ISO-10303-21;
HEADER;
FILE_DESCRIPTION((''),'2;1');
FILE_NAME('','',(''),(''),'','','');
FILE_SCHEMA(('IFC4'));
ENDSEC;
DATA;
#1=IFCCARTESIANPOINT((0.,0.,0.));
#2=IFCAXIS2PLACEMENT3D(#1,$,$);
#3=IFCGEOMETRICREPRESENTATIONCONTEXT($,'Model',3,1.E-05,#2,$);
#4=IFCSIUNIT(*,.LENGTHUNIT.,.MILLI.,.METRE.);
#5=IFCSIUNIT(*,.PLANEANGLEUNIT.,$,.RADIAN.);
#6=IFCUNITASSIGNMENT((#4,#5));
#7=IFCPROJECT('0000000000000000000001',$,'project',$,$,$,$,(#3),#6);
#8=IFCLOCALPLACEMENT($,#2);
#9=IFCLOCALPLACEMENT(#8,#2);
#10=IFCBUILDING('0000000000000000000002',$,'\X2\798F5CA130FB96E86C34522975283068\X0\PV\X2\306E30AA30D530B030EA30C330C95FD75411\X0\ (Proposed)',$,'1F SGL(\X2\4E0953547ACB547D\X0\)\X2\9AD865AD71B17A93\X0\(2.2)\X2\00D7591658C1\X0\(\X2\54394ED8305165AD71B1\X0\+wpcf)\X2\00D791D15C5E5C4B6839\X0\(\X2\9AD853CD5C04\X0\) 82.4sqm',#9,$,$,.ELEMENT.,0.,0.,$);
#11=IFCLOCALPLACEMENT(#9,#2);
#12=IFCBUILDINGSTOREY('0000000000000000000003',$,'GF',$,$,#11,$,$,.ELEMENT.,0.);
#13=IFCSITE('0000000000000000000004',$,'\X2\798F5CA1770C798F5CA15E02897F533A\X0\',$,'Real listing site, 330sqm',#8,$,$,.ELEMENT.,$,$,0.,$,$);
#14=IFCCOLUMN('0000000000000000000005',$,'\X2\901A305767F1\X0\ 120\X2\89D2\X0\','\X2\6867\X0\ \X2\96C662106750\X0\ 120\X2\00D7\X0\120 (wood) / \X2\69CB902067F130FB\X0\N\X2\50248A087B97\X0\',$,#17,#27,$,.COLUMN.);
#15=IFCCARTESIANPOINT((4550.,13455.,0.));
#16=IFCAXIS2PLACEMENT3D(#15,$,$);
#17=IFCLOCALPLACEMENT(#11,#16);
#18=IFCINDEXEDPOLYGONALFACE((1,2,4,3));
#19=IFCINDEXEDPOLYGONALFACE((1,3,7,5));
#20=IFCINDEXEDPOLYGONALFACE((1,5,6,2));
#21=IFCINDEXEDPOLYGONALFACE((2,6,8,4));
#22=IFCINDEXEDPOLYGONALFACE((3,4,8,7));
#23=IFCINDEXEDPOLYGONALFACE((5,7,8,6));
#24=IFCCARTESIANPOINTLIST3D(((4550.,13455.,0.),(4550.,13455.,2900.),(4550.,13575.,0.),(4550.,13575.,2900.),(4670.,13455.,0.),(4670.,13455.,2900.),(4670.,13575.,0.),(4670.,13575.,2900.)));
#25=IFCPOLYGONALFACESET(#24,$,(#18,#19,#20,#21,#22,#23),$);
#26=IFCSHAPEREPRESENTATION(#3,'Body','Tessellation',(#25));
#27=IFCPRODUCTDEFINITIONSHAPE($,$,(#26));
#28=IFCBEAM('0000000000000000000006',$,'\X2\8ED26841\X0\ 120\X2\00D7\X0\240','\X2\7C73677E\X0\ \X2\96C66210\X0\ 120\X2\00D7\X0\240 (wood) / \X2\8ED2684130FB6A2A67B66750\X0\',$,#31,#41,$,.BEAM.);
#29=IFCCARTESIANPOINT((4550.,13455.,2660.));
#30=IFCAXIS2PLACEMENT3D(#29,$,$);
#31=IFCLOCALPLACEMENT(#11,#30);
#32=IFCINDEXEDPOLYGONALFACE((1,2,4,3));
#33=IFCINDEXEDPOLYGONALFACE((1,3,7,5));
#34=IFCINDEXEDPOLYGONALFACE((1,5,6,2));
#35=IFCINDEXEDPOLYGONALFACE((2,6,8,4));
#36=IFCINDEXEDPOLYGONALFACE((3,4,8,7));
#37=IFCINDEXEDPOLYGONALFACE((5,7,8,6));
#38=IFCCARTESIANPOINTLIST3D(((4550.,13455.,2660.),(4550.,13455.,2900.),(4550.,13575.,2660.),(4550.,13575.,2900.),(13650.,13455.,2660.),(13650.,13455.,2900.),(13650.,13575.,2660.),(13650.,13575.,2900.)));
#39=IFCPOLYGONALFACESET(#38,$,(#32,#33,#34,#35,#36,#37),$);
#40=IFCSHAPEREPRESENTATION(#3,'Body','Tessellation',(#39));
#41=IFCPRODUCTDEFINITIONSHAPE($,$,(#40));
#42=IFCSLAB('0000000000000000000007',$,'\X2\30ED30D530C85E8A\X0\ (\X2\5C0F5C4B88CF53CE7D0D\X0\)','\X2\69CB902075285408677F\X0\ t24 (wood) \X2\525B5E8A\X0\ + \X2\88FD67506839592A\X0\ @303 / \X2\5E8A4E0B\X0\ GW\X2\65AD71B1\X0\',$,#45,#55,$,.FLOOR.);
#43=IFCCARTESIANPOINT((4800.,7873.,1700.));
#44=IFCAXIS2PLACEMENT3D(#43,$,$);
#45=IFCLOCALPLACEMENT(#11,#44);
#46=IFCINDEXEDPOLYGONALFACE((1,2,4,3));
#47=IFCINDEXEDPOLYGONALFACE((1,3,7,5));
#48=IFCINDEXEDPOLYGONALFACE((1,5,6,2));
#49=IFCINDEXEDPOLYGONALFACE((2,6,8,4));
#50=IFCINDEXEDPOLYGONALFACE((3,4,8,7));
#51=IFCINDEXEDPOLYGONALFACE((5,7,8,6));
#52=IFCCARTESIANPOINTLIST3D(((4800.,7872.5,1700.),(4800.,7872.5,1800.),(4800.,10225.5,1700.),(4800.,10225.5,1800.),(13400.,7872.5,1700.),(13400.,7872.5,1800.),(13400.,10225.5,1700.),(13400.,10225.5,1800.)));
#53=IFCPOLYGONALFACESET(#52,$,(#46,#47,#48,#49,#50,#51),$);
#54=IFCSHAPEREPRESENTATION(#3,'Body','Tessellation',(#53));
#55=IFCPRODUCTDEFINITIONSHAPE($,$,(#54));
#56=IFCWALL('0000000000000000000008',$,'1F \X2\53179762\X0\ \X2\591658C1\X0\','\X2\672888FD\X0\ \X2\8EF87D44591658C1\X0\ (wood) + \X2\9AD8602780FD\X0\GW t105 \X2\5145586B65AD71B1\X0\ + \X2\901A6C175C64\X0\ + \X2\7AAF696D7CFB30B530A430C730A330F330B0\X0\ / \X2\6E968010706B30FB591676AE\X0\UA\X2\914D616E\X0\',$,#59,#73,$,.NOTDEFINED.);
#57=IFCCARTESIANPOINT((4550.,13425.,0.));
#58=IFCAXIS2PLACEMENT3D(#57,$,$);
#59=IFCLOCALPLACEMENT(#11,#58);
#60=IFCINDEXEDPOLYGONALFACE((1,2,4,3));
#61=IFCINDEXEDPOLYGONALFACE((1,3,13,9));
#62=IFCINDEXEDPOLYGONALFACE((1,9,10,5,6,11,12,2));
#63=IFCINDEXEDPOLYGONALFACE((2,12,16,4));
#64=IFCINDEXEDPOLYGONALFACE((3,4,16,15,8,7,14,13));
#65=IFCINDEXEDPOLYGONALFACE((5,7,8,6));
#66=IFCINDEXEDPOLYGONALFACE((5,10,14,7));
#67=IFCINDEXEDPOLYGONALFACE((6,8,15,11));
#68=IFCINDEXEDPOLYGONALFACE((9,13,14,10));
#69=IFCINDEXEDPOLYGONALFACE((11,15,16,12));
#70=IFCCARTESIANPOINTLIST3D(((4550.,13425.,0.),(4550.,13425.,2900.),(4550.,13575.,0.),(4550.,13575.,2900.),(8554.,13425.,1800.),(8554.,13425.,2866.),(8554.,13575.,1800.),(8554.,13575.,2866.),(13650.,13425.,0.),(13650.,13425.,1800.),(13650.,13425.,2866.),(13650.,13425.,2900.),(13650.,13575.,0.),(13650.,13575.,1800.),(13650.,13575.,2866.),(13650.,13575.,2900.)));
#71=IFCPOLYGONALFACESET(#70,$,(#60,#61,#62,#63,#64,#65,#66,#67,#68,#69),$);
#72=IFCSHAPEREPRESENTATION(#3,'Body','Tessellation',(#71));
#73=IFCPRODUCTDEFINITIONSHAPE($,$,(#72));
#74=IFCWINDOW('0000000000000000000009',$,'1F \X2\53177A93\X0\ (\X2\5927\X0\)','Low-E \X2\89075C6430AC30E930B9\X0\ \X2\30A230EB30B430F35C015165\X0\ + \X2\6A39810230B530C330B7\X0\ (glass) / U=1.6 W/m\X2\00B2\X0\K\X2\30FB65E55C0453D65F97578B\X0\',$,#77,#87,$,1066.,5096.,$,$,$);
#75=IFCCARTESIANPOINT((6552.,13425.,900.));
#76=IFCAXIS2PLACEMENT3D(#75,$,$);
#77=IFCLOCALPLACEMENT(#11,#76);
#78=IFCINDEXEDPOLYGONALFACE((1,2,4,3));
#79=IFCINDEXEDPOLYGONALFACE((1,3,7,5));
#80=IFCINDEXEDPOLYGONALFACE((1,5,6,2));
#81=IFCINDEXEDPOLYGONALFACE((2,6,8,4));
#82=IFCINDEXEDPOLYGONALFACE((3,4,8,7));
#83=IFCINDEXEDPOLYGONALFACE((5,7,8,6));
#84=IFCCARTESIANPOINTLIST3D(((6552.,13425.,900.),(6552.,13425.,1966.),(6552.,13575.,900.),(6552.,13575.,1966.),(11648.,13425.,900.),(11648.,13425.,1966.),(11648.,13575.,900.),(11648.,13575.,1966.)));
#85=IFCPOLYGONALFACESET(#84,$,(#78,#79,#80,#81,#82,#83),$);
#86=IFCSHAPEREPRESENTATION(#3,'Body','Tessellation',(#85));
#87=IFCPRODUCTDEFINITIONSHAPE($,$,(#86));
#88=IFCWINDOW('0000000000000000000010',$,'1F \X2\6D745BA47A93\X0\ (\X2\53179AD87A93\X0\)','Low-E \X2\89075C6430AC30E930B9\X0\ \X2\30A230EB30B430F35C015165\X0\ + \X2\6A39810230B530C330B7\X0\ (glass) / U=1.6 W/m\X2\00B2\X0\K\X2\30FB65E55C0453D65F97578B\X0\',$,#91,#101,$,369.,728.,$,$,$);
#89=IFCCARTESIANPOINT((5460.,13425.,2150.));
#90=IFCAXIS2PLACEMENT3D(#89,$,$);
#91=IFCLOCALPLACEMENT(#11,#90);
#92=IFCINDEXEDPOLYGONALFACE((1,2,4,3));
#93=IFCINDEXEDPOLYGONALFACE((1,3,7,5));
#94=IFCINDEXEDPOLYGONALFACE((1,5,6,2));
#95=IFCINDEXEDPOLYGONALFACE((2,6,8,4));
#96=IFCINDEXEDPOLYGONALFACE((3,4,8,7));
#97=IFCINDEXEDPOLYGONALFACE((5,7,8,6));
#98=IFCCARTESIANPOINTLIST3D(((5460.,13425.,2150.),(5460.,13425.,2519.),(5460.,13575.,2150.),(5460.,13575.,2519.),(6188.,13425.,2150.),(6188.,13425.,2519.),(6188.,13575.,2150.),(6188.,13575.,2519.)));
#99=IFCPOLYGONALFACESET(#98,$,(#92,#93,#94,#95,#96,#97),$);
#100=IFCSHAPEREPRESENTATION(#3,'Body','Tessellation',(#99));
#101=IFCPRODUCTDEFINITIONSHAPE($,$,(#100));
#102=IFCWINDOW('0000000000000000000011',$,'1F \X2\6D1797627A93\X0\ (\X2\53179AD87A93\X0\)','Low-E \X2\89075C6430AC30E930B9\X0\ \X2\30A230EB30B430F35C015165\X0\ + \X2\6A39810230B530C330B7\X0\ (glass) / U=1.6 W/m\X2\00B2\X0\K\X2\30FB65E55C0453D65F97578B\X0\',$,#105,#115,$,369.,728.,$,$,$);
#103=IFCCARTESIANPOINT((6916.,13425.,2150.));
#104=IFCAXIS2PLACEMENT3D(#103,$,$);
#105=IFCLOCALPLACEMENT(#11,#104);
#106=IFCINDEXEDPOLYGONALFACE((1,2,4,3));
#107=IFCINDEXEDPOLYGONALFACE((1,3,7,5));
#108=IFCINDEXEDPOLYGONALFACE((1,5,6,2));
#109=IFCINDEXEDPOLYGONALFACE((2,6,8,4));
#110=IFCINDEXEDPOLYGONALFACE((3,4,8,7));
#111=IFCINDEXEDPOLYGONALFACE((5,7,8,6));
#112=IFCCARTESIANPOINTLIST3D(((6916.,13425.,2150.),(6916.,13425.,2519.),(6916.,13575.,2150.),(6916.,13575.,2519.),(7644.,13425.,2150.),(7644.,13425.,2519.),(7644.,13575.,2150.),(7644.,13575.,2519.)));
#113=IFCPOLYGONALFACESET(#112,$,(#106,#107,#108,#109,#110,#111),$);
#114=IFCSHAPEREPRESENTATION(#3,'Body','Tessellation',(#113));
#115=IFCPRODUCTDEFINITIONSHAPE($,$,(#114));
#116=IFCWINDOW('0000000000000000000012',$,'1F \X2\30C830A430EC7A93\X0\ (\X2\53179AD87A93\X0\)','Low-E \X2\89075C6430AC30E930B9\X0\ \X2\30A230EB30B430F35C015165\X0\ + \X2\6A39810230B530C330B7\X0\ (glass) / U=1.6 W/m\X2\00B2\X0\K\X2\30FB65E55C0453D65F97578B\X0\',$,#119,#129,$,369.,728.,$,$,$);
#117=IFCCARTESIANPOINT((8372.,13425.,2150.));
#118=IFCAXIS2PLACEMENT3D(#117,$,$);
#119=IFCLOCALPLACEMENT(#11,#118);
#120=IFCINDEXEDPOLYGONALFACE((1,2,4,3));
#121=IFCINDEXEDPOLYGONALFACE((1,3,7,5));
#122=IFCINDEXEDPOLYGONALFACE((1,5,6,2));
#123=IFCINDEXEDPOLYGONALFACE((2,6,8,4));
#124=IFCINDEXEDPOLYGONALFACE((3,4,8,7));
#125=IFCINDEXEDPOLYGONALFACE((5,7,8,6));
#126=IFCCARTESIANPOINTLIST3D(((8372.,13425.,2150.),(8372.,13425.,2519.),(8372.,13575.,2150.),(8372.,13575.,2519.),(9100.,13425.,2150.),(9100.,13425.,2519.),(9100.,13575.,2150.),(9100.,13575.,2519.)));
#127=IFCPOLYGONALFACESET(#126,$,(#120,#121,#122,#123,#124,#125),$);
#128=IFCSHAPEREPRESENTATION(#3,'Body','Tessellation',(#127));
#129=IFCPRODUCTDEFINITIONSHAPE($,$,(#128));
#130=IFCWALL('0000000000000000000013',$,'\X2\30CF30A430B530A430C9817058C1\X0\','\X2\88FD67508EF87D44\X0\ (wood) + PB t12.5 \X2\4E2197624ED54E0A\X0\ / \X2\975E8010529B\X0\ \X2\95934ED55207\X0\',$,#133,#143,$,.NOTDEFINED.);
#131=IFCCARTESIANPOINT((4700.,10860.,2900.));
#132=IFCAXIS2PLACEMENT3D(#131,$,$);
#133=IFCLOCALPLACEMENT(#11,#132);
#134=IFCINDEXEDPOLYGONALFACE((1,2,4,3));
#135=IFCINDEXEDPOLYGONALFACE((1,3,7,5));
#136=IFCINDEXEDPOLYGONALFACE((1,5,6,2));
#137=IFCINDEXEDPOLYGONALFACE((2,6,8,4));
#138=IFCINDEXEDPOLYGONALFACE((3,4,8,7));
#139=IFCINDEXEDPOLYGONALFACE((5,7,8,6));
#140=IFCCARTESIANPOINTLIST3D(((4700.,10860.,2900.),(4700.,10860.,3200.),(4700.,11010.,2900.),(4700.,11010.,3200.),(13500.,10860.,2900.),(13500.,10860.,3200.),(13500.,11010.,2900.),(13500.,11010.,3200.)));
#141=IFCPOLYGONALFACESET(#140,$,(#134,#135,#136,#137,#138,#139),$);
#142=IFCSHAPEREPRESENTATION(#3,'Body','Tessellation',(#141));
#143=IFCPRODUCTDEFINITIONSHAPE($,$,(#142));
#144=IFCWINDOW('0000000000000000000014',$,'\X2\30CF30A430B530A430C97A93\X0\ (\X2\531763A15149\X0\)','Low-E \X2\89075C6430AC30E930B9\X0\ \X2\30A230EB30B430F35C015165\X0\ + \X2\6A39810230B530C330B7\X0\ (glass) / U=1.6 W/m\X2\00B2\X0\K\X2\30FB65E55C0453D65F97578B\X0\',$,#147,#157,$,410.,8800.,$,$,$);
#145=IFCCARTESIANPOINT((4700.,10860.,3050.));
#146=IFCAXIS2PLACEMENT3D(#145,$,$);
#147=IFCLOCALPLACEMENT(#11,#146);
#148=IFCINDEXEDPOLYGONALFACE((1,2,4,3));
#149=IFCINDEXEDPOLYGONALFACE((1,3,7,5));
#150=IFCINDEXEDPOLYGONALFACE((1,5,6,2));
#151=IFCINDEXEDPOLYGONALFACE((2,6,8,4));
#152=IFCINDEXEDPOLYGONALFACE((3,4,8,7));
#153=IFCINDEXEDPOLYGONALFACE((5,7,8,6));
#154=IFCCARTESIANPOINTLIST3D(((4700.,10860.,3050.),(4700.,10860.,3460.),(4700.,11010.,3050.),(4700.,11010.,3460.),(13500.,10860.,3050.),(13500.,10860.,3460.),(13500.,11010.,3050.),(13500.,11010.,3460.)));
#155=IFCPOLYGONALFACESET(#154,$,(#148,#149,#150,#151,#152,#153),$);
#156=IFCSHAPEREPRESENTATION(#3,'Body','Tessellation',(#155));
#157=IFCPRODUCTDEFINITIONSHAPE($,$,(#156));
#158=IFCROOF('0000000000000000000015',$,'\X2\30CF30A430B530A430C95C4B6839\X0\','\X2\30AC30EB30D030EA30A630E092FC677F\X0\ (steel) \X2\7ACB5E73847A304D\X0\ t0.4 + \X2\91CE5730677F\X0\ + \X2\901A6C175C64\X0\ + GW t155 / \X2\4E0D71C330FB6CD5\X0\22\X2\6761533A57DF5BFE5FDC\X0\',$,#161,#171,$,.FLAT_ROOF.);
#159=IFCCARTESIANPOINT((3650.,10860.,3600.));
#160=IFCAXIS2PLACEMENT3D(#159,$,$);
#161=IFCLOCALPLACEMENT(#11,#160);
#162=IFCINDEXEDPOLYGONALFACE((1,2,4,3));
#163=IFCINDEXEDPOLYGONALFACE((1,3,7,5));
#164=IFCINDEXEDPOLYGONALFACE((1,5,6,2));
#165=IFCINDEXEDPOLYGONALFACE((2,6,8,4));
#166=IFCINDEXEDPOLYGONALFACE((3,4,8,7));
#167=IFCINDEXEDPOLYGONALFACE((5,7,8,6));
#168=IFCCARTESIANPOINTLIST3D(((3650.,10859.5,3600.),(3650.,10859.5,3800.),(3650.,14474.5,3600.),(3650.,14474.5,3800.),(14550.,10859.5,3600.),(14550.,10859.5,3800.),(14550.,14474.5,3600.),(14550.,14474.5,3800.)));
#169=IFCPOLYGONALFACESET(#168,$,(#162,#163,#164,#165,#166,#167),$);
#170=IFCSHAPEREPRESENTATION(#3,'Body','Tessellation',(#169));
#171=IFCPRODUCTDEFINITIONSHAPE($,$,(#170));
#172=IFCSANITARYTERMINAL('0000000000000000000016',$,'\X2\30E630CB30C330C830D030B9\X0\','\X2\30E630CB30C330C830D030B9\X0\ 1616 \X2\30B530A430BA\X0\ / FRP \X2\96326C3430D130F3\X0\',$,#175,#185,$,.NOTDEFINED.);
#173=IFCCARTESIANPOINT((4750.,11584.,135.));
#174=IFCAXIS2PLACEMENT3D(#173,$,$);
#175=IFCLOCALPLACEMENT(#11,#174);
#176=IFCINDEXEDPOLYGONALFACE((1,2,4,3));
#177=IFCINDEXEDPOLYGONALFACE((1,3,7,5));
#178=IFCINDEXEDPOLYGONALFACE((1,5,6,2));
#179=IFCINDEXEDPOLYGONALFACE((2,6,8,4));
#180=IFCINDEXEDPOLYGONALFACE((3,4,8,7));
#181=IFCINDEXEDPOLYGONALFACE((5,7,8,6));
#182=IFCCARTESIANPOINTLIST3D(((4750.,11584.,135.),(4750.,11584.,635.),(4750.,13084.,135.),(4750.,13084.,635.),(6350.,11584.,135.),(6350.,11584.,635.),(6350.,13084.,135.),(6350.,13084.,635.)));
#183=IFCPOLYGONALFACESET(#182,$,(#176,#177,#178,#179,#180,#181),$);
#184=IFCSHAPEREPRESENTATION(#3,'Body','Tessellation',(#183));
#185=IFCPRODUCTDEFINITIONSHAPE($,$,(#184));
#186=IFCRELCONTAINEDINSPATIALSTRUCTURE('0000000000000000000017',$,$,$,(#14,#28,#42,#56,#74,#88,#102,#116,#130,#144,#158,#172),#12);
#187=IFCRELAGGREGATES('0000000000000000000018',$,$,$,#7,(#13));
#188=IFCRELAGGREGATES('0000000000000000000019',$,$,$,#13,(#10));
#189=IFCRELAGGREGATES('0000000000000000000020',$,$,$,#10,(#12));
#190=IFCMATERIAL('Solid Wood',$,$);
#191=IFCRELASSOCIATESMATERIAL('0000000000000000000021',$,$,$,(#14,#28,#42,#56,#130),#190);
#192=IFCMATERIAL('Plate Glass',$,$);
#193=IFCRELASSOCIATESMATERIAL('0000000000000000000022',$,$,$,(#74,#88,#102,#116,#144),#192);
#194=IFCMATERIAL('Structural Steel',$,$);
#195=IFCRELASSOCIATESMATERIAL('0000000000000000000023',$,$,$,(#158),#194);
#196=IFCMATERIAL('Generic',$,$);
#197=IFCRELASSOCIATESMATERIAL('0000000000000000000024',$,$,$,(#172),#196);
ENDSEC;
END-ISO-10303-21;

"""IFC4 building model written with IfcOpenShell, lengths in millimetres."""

from ifc_helpers import new_model, si_unit, frame, frame_2d, origin, place, context, project, spatial, rectangle, extrude, material, element, fill, save


model = new_model("IFC4")

# Units and contexts
model_context = context("Model", 3, precision=1e-05, world=origin())
ifc_project = project(units=[si_unit("LENGTHUNIT", "METRE", prefix="MILLI"), si_unit("PLANEANGLEUNIT", "RADIAN")], contexts=[model_context])

# Site, building, storey
site_placement = place(None, origin())
site = spatial("IfcSite", under=ifc_project, at=site_placement, Name="福岡県福岡市西区", ObjectType="Real listing site, 330sqm", CompositionType="ELEMENT", RefElevation=0.0)
building_placement = place(site_placement, origin())
building = spatial("IfcBuilding", under=site, at=building_placement, Name="福岡・雨水利用とPVのオフグリッド志向 (Proposed)", ObjectType="1F SGL(三協立命)高断熱窓(2.2)×外壁(吹付け断熱+wpcf)×金属屋根(高反射) 82.4sqm", CompositionType="ELEMENT", ElevationOfRefHeight=0.0, ElevationOfTerrain=0.0)
storey_placement = place(building_placement, origin())
storey = spatial("IfcBuildingStorey", under=building, at=storey_placement, Name="GF", CompositionType="ELEMENT", Elevation=0.0)

# Column
ifc_material_1 = material(Name="Solid Wood")
column_1_placement = place(storey_placement, frame((4550.0, 13455.0, 0.0)))
element("IfcColumn", 1, at=column_1_placement, inside=storey, material=ifc_material_1, Name="通し柱 120角", Description="桧 集成材 120×120 (wood) / 構造柱・N値計算", PredefinedType="COLUMN", context=model_context, shape_type="SweptSolid", body=[
    extrude(rectangle(XDim=120.0, YDim=120.0, at=frame_2d((60.0, 60.0))), frame((4550.0, 13455.0, 0.0)), (0.0, 0.0, 1.0), 2900.0),
])

# Beam
beam_1_placement = place(storey_placement, frame((4550.0, 13455.0, 2660.0)))
element("IfcBeam", 2, at=beam_1_placement, inside=storey, material=ifc_material_1, Name="軒桁 120×240", Description="米松 集成 120×240 (wood) / 軒桁・横架材", PredefinedType="BEAM", context=model_context, shape_type="SweptSolid", body=[
    extrude(rectangle(XDim=9100.0, YDim=120.0, at=frame_2d((4550.0, 60.0))), frame((4550.0, 13455.0, 2660.0)), (0.0, 0.0, 1.0), 240.0),
])

# Slab
slab_placement = place(storey_placement, frame((4800.0, 7873.0, 1700.0)))
element("IfcSlab", 3, at=slab_placement, inside=storey, material=ifc_material_1, Name="ロフト床 (小屋裏収納)", Description="構造用合板 t24 (wood) 剛床 + 製材根太 @303 / 床下 GW断熱", PredefinedType="FLOOR", context=model_context, shape_type="SweptSolid", body=[
    extrude(rectangle(XDim=8600.0, YDim=2353.0, at=frame_2d((4300.0, 1176.0))), frame((4800.0, 7873.0, 1700.0)), (0.0, 0.0, 1.0), 100.0),
])

# Wall, openings, windows
wall_1_placement = place(storey_placement, frame((4550.0, 13425.0, 0.0)))
wall_1 = element("IfcWall", 4, at=wall_1_placement, inside=storey, material=ifc_material_1, Name="1F 北面 外壁", Description="木製 軸組外壁 (wood) + 高性能GW t105 充填断熱 + 通気層 + 窯業系サイディング / 準耐火・外皮UA配慮", PredefinedType="NOTDEFINED", context=model_context, shape_type="SweptSolid", body=[
    extrude(rectangle(XDim=9100.0, YDim=150.0, at=frame_2d((4550.0, 75.0))), frame((4550.0, 13425.0, 0.0)), (0.0, 0.0, 1.0), 2900.0),
])
opening_1_placement = place(storey_placement, frame((6552.0, 13425.0, 900.0)))
opening_1 = element("IfcOpeningElement", 5, at=opening_1_placement, cuts=wall_1, PredefinedType="NOTDEFINED", context=model_context, shape_type="SweptSolid", body=[
    extrude(rectangle(XDim=5096.0, YDim=150.0, at=frame_2d((2548.0, 75.0))), frame((6552.0, 13425.0, 900.0)), (0.0, 0.0, 1.0), 1066.0),
])
opening_2_placement = place(storey_placement, frame((5460.0, 13425.0, 2150.0)))
opening_2 = element("IfcOpeningElement", 6, at=opening_2_placement, cuts=wall_1, PredefinedType="NOTDEFINED", context=model_context, shape_type="SweptSolid", body=[
    extrude(rectangle(XDim=728.0, YDim=150.0, at=frame_2d((364.0, 75.0))), frame((5460.0, 13425.0, 2150.0)), (0.0, 0.0, 1.0), 369.0),
])
opening_3_placement = place(storey_placement, frame((6916.0, 13425.0, 2150.0)))
opening_3 = element("IfcOpeningElement", 7, at=opening_3_placement, cuts=wall_1, PredefinedType="NOTDEFINED", context=model_context, shape_type="SweptSolid", body=[
    extrude(rectangle(XDim=728.0, YDim=150.0, at=frame_2d((364.0, 75.0))), frame((6916.0, 13425.0, 2150.0)), (0.0, 0.0, 1.0), 369.0),
])
opening_4_placement = place(storey_placement, frame((8372.0, 13425.0, 2150.0)))
opening_4 = element("IfcOpeningElement", 8, at=opening_4_placement, cuts=wall_1, PredefinedType="NOTDEFINED", context=model_context, shape_type="SweptSolid", body=[
    extrude(rectangle(XDim=728.0, YDim=150.0, at=frame_2d((364.0, 75.0))), frame((8372.0, 13425.0, 2150.0)), (0.0, 0.0, 1.0), 369.0),
])
ifc_material_2 = material(Name="Plate Glass")
window_1_placement = place(storey_placement, frame((6552.0, 13425.0, 900.0)))
window_1 = element("IfcWindow", 9, at=window_1_placement, inside=storey, material=ifc_material_2, Name="1F 北窓 (大)", Description="Low-E 複層ガラス アルゴン封入 + 樹脂サッシ (glass) / U=1.6 W/m²K・日射取得型", OverallHeight=1066.0, OverallWidth=5096.0, context=model_context, shape_type="SweptSolid", body=[
    extrude(rectangle(XDim=5096.0, YDim=150.0, at=frame_2d((2548.0, 75.0))), frame((6552.0, 13425.0, 900.0)), (0.0, 0.0, 1.0), 1066.0),
])
fill(opening_1, window_1)
window_2_placement = place(storey_placement, frame((5460.0, 13425.0, 2150.0)))
window_2 = element("IfcWindow", 10, at=window_2_placement, inside=storey, material=ifc_material_2, Name="1F 浴室窓 (北高窓)", Description="Low-E 複層ガラス アルゴン封入 + 樹脂サッシ (glass) / U=1.6 W/m²K・日射取得型", OverallHeight=369.0, OverallWidth=728.0, context=model_context, shape_type="SweptSolid", body=[
    extrude(rectangle(XDim=728.0, YDim=150.0, at=frame_2d((364.0, 75.0))), frame((5460.0, 13425.0, 2150.0)), (0.0, 0.0, 1.0), 369.0),
])
fill(opening_2, window_2)
window_3_placement = place(storey_placement, frame((6916.0, 13425.0, 2150.0)))
window_3 = element("IfcWindow", 11, at=window_3_placement, inside=storey, material=ifc_material_2, Name="1F 洗面窓 (北高窓)", Description="Low-E 複層ガラス アルゴン封入 + 樹脂サッシ (glass) / U=1.6 W/m²K・日射取得型", OverallHeight=369.0, OverallWidth=728.0, context=model_context, shape_type="SweptSolid", body=[
    extrude(rectangle(XDim=728.0, YDim=150.0, at=frame_2d((364.0, 75.0))), frame((6916.0, 13425.0, 2150.0)), (0.0, 0.0, 1.0), 369.0),
])
fill(opening_3, window_3)
window_4_placement = place(storey_placement, frame((8372.0, 13425.0, 2150.0)))
window_4 = element("IfcWindow", 12, at=window_4_placement, inside=storey, material=ifc_material_2, Name="1F トイレ窓 (北高窓)", Description="Low-E 複層ガラス アルゴン封入 + 樹脂サッシ (glass) / U=1.6 W/m²K・日射取得型", OverallHeight=369.0, OverallWidth=728.0, context=model_context, shape_type="SweptSolid", body=[
    extrude(rectangle(XDim=728.0, YDim=150.0, at=frame_2d((364.0, 75.0))), frame((8372.0, 13425.0, 2150.0)), (0.0, 0.0, 1.0), 369.0),
])
fill(opening_4, window_4)

# Wall, opening, window
wall_2_placement = place(storey_placement, frame((4700.0, 10860.0, 2900.0)))
wall_2 = element("IfcWall", 13, at=wall_2_placement, inside=storey, material=ifc_material_1, Name="ハイサイド腰壁", Description="製材軸組 (wood) + PB t12.5 両面仕上 / 非耐力 間仕切", PredefinedType="NOTDEFINED", context=model_context, shape_type="SweptSolid", body=[
    extrude(rectangle(XDim=8800.0, YDim=150.0, at=frame_2d((4400.0, 75.0))), frame((4700.0, 10860.0, 2900.0)), (0.0, 0.0, 1.0), 700.0),
])
opening_5_placement = place(storey_placement, frame((4700.0, 10860.0, 3050.0)))
opening_5 = element("IfcOpeningElement", 14, at=opening_5_placement, cuts=wall_2, PredefinedType="NOTDEFINED", context=model_context, shape_type="SweptSolid", body=[
    extrude(rectangle(XDim=8800.0, YDim=150.0, at=frame_2d((4400.0, 75.0))), frame((4700.0, 10860.0, 3050.0)), (0.0, 0.0, 1.0), 410.0),
])
window_5_placement = place(storey_placement, frame((4700.0, 10860.0, 3050.0)))
window_5 = element("IfcWindow", 15, at=window_5_placement, inside=storey, material=ifc_material_2, Name="ハイサイド窓 (北採光)", Description="Low-E 複層ガラス アルゴン封入 + 樹脂サッシ (glass) / U=1.6 W/m²K・日射取得型", OverallHeight=410.0, OverallWidth=8800.0, context=model_context, shape_type="SweptSolid", body=[
    extrude(rectangle(XDim=8800.0, YDim=150.0, at=frame_2d((4400.0, 75.0))), frame((4700.0, 10860.0, 3050.0)), (0.0, 0.0, 1.0), 410.0),
])
fill(opening_5, window_5)

# Roof
ifc_material_3 = material(Name="Structural Steel")
roof_placement = place(storey_placement, frame((3650.0, 10860.0, 3600.0)))
element("IfcRoof", 16, at=roof_placement, inside=storey, material=ifc_material_3, Name="ハイサイド屋根", Description="ガルバリウム鋼板 (steel) 立平葺き t0.4 + 野地板 + 通気層 + GW t155 / 不燃・法22条区域対応", PredefinedType="FLAT_ROOF", context=model_context, shape_type="SweptSolid", body=[
    extrude(rectangle(XDim=10900.0, YDim=3615.0, at=frame_2d((5450.0, 1807.0))), frame((3650.0, 10860.0, 3600.0)), (0.0, 0.0, 1.0), 200.0),
])

# Sanitary terminal
ifc_material_4 = material(Name="Generic")
sanitary_terminal_placement = place(storey_placement, frame((4750.0, 11584.0, 135.0)))
element("IfcSanitaryTerminal", 17, at=sanitary_terminal_placement, inside=storey, material=ifc_material_4, Name="ユニットバス", Description="ユニットバス 1616 サイズ / FRP 防水パン", PredefinedType="NOTDEFINED", context=model_context, shape_type="SweptSolid", body=[
    extrude(rectangle(XDim=1600.0, YDim=1500.0, at=frame_2d((800.0, 750.0))), frame((4750.0, 11584.0, 135.0)), (0.0, 0.0, 1.0), 500.0),
])

save(model, "model.ifc")
